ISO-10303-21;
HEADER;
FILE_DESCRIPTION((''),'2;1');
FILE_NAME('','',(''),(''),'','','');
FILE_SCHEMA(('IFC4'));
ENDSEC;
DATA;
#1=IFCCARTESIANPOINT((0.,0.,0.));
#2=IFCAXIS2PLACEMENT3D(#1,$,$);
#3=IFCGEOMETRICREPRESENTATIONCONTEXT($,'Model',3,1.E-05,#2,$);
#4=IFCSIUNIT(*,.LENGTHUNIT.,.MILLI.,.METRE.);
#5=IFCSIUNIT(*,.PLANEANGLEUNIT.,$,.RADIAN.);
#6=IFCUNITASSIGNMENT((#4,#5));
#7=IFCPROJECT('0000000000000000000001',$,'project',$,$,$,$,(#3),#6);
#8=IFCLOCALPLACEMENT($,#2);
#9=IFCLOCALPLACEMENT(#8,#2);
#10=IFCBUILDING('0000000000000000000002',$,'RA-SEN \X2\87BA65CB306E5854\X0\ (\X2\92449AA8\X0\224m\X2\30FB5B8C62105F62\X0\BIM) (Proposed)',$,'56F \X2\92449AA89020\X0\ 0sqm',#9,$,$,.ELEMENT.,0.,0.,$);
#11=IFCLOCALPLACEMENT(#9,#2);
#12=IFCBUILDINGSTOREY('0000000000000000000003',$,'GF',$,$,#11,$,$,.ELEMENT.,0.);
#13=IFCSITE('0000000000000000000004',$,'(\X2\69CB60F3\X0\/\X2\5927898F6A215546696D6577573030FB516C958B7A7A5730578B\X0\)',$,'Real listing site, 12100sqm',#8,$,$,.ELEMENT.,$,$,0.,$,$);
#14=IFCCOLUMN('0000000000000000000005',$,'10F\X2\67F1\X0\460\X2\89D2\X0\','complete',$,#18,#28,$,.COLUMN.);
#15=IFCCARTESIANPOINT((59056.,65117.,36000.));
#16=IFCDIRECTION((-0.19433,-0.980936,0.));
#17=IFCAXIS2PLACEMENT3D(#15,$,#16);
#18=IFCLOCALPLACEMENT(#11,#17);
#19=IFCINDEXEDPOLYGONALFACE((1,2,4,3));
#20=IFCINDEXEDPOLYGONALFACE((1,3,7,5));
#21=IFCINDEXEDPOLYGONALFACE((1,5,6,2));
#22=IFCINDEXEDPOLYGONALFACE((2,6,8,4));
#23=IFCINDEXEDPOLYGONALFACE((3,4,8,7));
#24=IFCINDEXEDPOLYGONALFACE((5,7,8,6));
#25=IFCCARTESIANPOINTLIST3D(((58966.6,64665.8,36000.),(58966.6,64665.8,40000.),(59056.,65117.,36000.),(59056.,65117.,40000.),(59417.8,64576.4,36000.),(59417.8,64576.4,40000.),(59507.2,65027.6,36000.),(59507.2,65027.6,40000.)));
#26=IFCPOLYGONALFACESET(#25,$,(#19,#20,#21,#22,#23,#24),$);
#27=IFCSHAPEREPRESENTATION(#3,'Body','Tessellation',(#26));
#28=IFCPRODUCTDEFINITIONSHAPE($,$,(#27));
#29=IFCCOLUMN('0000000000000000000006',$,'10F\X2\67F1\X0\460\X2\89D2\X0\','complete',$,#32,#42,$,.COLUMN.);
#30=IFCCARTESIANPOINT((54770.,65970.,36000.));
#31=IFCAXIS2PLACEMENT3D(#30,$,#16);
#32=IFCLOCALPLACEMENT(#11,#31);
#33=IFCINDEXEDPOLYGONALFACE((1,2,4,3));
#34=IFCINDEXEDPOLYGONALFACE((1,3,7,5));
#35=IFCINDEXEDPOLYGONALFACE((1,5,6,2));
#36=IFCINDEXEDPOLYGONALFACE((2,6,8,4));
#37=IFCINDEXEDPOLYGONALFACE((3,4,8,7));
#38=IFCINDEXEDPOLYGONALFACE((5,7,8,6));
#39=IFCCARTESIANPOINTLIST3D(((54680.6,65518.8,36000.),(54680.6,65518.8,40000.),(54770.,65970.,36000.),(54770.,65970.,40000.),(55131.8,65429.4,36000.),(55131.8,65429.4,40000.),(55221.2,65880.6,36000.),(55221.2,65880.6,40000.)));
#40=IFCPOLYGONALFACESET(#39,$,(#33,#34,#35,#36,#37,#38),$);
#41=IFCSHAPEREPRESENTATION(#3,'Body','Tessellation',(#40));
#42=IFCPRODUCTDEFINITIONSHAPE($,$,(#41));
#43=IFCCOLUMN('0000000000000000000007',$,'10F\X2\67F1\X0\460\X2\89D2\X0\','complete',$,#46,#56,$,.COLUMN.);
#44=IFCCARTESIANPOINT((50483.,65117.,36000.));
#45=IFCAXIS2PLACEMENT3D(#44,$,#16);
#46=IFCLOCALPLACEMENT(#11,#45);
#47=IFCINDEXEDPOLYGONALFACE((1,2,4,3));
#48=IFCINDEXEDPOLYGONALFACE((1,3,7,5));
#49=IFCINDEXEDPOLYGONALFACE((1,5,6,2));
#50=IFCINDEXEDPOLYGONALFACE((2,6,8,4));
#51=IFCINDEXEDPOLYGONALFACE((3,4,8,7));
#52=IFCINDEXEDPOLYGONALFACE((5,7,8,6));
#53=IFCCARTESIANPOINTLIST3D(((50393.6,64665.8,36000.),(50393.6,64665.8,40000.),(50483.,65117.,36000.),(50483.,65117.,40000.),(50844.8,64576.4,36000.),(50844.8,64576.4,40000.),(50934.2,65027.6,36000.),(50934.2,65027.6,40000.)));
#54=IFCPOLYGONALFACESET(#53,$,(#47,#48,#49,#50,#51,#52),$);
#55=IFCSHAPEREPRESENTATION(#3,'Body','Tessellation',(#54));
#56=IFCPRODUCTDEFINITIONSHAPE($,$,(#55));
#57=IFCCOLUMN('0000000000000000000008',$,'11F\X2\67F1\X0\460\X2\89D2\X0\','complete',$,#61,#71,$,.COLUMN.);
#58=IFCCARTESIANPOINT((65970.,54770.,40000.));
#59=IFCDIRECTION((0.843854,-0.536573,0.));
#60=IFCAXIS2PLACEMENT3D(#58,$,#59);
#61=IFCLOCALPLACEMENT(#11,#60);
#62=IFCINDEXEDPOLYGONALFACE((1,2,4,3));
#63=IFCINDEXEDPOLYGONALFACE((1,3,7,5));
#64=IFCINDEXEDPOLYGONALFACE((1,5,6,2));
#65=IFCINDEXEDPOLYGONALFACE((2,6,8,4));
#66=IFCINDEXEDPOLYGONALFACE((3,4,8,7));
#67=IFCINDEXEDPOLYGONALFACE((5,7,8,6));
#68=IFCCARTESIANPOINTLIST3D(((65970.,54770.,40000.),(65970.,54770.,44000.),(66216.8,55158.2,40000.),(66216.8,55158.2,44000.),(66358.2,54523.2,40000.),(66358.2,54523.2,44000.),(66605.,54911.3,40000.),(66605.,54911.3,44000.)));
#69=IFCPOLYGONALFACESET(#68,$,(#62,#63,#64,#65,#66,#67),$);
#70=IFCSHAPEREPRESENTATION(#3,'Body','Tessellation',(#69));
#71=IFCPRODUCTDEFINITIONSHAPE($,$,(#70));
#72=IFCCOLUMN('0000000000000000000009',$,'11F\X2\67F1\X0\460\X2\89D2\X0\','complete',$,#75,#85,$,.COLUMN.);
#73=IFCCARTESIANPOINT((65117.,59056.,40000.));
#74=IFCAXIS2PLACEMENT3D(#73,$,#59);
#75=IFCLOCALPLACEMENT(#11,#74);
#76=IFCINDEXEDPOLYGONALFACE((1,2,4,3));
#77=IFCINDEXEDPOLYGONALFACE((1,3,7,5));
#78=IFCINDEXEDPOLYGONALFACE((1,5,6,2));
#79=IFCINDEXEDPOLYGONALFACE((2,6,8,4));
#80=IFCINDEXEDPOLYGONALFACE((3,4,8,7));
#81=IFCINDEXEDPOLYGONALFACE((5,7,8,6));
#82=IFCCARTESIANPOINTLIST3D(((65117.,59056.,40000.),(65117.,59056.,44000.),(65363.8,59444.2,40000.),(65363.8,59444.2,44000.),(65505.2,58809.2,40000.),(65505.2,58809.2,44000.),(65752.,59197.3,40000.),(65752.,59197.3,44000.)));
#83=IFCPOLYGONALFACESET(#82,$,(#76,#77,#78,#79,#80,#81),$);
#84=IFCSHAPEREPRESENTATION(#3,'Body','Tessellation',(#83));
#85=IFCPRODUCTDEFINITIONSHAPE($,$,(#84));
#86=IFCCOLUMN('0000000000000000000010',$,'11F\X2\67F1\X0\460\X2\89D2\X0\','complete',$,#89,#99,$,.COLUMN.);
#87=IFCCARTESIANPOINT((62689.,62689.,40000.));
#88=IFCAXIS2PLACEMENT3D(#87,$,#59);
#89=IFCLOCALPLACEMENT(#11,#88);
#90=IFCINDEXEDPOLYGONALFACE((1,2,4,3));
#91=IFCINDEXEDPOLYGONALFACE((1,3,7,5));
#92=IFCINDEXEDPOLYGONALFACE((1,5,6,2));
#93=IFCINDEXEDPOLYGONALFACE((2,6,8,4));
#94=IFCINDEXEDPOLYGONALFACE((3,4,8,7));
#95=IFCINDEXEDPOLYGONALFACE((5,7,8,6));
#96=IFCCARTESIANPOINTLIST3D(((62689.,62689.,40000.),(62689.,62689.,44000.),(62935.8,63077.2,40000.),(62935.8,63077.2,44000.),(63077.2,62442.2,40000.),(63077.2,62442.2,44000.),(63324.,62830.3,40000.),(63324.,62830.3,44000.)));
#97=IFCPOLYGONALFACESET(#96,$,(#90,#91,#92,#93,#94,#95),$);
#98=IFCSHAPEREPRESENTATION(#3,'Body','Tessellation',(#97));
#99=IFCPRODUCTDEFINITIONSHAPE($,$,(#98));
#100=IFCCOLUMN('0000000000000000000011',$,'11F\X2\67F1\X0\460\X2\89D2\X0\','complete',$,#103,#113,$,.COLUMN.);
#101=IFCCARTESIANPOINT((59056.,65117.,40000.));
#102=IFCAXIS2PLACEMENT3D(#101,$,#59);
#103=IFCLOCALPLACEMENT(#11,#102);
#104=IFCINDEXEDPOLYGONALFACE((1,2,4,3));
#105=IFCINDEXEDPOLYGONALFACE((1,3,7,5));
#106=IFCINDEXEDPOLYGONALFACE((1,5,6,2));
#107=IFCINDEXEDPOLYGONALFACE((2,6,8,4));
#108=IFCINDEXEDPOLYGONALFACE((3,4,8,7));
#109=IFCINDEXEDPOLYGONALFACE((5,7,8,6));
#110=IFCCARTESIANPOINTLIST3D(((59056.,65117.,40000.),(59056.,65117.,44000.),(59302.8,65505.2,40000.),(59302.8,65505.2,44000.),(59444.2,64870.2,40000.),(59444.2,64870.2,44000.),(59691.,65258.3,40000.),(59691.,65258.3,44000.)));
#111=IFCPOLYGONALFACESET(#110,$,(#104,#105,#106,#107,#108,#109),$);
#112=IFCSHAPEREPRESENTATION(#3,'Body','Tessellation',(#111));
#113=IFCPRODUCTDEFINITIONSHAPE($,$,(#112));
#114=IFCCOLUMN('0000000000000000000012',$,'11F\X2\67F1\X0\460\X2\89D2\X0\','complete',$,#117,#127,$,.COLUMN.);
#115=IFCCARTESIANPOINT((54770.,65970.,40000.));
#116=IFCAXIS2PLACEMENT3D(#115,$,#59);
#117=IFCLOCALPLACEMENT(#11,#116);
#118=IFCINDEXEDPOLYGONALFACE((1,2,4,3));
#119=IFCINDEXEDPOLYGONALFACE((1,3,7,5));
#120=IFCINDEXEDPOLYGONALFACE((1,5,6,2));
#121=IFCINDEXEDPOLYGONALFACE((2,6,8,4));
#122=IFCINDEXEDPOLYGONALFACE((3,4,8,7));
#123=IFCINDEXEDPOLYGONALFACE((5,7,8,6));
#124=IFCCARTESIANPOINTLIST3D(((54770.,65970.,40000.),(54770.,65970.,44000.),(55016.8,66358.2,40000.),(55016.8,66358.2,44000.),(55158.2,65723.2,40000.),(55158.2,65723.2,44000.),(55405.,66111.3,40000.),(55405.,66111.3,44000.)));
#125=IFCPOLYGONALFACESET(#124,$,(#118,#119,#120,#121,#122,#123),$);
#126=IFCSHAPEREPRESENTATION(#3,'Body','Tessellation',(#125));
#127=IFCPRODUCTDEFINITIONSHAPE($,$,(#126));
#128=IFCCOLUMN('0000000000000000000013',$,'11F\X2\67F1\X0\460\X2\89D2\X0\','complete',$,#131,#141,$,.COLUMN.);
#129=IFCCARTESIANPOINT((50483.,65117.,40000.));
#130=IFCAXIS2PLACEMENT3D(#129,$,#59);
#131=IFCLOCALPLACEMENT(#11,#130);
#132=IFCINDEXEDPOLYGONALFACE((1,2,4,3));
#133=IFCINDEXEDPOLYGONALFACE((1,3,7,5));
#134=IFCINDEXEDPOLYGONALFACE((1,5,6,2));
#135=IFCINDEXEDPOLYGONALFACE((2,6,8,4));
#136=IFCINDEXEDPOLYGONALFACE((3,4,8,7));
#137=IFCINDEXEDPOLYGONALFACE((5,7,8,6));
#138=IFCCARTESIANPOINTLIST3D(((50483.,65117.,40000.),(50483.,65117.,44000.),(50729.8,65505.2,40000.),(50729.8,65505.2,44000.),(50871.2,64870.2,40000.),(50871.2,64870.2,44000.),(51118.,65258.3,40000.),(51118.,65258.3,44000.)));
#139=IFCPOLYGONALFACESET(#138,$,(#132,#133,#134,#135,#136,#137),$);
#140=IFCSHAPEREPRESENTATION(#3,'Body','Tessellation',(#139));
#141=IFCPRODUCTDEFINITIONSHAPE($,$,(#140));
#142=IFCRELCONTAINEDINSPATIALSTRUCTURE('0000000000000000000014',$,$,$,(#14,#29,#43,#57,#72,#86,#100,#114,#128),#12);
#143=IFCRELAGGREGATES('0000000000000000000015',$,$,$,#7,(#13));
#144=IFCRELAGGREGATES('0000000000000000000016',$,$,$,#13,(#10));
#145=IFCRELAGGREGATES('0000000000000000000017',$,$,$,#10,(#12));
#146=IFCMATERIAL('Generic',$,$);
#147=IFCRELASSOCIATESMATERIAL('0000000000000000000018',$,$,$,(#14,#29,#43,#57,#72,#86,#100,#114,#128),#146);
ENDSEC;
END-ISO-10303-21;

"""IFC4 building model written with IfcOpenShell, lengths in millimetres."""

from ifc_helpers import new_model, si_unit, frame, frame_2d, origin, place, context, project, spatial, rectangle, extrude, material, element, save


model = new_model("IFC4")

# Units and contexts
model_context = context("Model", 3, precision=1e-05, world=origin())
ifc_project = project(units=[si_unit("LENGTHUNIT", "METRE", prefix="MILLI"), si_unit("PLANEANGLEUNIT", "RADIAN")], contexts=[model_context])

# Site, building, storey
site_placement = place(None, origin())
site = spatial("IfcSite", under=ifc_project, at=site_placement, Name="(構想/大規模商業敷地・公開空地型)", ObjectType="Real listing site, 12100sqm", CompositionType="ELEMENT", RefElevation=0.0)
building_placement = place(site_placement, origin())
building = spatial("IfcBuilding", under=site, at=building_placement, Name="RA-SEN 螺旋の塔 (鉄骨224m・完成形BIM) (Proposed)", ObjectType="56F 鉄骨造 0sqm", CompositionType="ELEMENT", ElevationOfRefHeight=0.0, ElevationOfTerrain=0.0)
storey_placement = place(building_placement, origin())
storey = spatial("IfcBuildingStorey", under=building, at=storey_placement, Name="GF", CompositionType="ELEMENT", Elevation=0.0)

# Columns
ifc_material = material(Name="Generic")
column_1_placement = place(storey_placement, frame((59056.0, 65117.0, 36000.0), x_axis=(-0.19433, -0.980936, 0.0)))
element("IfcColumn", 1, at=column_1_placement, inside=storey, material=ifc_material, Name="10F柱460角", Description="complete", PredefinedType="COLUMN", context=model_context, shape_type="SweptSolid", body=[
    extrude(rectangle(XDim=460.0, YDim=460.0, at=frame_2d((230.0, 230.0))), frame((59056.0, 65117.0, 36000.0), x_axis=(-0.19433, -0.980936, 0.0)), (0.0, 0.0, 1.0), 4000.0),
])
column_2_placement = place(storey_placement, frame((54770.0, 65970.0, 36000.0), x_axis=(-0.19433, -0.980936, 0.0)))
element("IfcColumn", 2, at=column_2_placement, inside=storey, material=ifc_material, Name="10F柱460角", Description="complete", PredefinedType="COLUMN", context=model_context, shape_type="SweptSolid", body=[
    extrude(rectangle(XDim=460.0, YDim=460.0, at=frame_2d((230.0, 230.0))), frame((54770.0, 65970.0, 36000.0), x_axis=(-0.19433, -0.980936, 0.0)), (0.0, 0.0, 1.0), 4000.0),
])
column_3_placement = place(storey_placement, frame((50483.0, 65117.0, 36000.0), x_axis=(-0.19433, -0.980936, 0.0)))
element("IfcColumn", 3, at=column_3_placement, inside=storey, material=ifc_material, Name="10F柱460角", Description="complete", PredefinedType="COLUMN", context=model_context, shape_type="SweptSolid", body=[
    extrude(rectangle(XDim=460.0, YDim=460.0, at=frame_2d((230.0, 230.0))), frame((50483.0, 65117.0, 36000.0), x_axis=(-0.19433, -0.980936, 0.0)), (0.0, 0.0, 1.0), 4000.0),
])
column_4_placement = place(storey_placement, frame((65970.0, 54770.0, 40000.0), x_axis=(0.843854, -0.536573, 0.0)))
element("IfcColumn", 4, at=column_4_placement, inside=storey, material=ifc_material, Name="11F柱460角", Description="complete", PredefinedType="COLUMN", context=model_context, shape_type="SweptSolid", body=[
    extrude(rectangle(XDim=460.0, YDim=460.0, at=frame_2d((230.0, 230.0))), frame((65970.0, 54770.0, 40000.0), x_axis=(0.843854, -0.536573, 0.0)), (0.0, 0.0, 1.0), 4000.0),
])
column_5_placement = place(storey_placement, frame((65117.0, 59056.0, 40000.0), x_axis=(0.843854, -0.536573, 0.0)))
element("IfcColumn", 5, at=column_5_placement, inside=storey, material=ifc_material, Name="11F柱460角", Description="complete", PredefinedType="COLUMN", context=model_context, shape_type="SweptSolid", body=[
    extrude(rectangle(XDim=460.0, YDim=460.0, at=frame_2d((230.0, 230.0))), frame((65117.0, 59056.0, 40000.0), x_axis=(0.843854, -0.536573, 0.0)), (0.0, 0.0, 1.0), 4000.0),
])
column_6_placement = place(storey_placement, frame((62689.0, 62689.0, 40000.0), x_axis=(0.843854, -0.536573, 0.0)))
element("IfcColumn", 6, at=column_6_placement, inside=storey, material=ifc_material, Name="11F柱460角", Description="complete", PredefinedType="COLUMN", context=model_context, shape_type="SweptSolid", body=[
    extrude(rectangle(XDim=460.0, YDim=460.0, at=frame_2d((230.0, 230.0))), frame((62689.0, 62689.0, 40000.0), x_axis=(0.843854, -0.536573, 0.0)), (0.0, 0.0, 1.0), 4000.0),
])
column_7_placement = place(storey_placement, frame((59056.0, 65117.0, 40000.0), x_axis=(0.843854, -0.536573, 0.0)))
element("IfcColumn", 7, at=column_7_placement, inside=storey, material=ifc_material, Name="11F柱460角", Description="complete", PredefinedType="COLUMN", context=model_context, shape_type="SweptSolid", body=[
    extrude(rectangle(XDim=460.0, YDim=460.0, at=frame_2d((230.0, 230.0))), frame((59056.0, 65117.0, 40000.0), x_axis=(0.843854, -0.536573, 0.0)), (0.0, 0.0, 1.0), 4000.0),
])
column_8_placement = place(storey_placement, frame((54770.0, 65970.0, 40000.0), x_axis=(0.843854, -0.536573, 0.0)))
element("IfcColumn", 8, at=column_8_placement, inside=storey, material=ifc_material, Name="11F柱460角", Description="complete", PredefinedType="COLUMN", context=model_context, shape_type="SweptSolid", body=[
    extrude(rectangle(XDim=460.0, YDim=460.0, at=frame_2d((230.0, 230.0))), frame((54770.0, 65970.0, 40000.0), x_axis=(0.843854, -0.536573, 0.0)), (0.0, 0.0, 1.0), 4000.0),
])
column_9_placement = place(storey_placement, frame((50483.0, 65117.0, 40000.0), x_axis=(0.843854, -0.536573, 0.0)))
element("IfcColumn", 9, at=column_9_placement, inside=storey, material=ifc_material, Name="11F柱460角", Description="complete", PredefinedType="COLUMN", context=model_context, shape_type="SweptSolid", body=[
    extrude(rectangle(XDim=460.0, YDim=460.0, at=frame_2d((230.0, 230.0))), frame((50483.0, 65117.0, 40000.0), x_axis=(0.843854, -0.536573, 0.0)), (0.0, 0.0, 1.0), 4000.0),
])

save(model, "model.ifc")
